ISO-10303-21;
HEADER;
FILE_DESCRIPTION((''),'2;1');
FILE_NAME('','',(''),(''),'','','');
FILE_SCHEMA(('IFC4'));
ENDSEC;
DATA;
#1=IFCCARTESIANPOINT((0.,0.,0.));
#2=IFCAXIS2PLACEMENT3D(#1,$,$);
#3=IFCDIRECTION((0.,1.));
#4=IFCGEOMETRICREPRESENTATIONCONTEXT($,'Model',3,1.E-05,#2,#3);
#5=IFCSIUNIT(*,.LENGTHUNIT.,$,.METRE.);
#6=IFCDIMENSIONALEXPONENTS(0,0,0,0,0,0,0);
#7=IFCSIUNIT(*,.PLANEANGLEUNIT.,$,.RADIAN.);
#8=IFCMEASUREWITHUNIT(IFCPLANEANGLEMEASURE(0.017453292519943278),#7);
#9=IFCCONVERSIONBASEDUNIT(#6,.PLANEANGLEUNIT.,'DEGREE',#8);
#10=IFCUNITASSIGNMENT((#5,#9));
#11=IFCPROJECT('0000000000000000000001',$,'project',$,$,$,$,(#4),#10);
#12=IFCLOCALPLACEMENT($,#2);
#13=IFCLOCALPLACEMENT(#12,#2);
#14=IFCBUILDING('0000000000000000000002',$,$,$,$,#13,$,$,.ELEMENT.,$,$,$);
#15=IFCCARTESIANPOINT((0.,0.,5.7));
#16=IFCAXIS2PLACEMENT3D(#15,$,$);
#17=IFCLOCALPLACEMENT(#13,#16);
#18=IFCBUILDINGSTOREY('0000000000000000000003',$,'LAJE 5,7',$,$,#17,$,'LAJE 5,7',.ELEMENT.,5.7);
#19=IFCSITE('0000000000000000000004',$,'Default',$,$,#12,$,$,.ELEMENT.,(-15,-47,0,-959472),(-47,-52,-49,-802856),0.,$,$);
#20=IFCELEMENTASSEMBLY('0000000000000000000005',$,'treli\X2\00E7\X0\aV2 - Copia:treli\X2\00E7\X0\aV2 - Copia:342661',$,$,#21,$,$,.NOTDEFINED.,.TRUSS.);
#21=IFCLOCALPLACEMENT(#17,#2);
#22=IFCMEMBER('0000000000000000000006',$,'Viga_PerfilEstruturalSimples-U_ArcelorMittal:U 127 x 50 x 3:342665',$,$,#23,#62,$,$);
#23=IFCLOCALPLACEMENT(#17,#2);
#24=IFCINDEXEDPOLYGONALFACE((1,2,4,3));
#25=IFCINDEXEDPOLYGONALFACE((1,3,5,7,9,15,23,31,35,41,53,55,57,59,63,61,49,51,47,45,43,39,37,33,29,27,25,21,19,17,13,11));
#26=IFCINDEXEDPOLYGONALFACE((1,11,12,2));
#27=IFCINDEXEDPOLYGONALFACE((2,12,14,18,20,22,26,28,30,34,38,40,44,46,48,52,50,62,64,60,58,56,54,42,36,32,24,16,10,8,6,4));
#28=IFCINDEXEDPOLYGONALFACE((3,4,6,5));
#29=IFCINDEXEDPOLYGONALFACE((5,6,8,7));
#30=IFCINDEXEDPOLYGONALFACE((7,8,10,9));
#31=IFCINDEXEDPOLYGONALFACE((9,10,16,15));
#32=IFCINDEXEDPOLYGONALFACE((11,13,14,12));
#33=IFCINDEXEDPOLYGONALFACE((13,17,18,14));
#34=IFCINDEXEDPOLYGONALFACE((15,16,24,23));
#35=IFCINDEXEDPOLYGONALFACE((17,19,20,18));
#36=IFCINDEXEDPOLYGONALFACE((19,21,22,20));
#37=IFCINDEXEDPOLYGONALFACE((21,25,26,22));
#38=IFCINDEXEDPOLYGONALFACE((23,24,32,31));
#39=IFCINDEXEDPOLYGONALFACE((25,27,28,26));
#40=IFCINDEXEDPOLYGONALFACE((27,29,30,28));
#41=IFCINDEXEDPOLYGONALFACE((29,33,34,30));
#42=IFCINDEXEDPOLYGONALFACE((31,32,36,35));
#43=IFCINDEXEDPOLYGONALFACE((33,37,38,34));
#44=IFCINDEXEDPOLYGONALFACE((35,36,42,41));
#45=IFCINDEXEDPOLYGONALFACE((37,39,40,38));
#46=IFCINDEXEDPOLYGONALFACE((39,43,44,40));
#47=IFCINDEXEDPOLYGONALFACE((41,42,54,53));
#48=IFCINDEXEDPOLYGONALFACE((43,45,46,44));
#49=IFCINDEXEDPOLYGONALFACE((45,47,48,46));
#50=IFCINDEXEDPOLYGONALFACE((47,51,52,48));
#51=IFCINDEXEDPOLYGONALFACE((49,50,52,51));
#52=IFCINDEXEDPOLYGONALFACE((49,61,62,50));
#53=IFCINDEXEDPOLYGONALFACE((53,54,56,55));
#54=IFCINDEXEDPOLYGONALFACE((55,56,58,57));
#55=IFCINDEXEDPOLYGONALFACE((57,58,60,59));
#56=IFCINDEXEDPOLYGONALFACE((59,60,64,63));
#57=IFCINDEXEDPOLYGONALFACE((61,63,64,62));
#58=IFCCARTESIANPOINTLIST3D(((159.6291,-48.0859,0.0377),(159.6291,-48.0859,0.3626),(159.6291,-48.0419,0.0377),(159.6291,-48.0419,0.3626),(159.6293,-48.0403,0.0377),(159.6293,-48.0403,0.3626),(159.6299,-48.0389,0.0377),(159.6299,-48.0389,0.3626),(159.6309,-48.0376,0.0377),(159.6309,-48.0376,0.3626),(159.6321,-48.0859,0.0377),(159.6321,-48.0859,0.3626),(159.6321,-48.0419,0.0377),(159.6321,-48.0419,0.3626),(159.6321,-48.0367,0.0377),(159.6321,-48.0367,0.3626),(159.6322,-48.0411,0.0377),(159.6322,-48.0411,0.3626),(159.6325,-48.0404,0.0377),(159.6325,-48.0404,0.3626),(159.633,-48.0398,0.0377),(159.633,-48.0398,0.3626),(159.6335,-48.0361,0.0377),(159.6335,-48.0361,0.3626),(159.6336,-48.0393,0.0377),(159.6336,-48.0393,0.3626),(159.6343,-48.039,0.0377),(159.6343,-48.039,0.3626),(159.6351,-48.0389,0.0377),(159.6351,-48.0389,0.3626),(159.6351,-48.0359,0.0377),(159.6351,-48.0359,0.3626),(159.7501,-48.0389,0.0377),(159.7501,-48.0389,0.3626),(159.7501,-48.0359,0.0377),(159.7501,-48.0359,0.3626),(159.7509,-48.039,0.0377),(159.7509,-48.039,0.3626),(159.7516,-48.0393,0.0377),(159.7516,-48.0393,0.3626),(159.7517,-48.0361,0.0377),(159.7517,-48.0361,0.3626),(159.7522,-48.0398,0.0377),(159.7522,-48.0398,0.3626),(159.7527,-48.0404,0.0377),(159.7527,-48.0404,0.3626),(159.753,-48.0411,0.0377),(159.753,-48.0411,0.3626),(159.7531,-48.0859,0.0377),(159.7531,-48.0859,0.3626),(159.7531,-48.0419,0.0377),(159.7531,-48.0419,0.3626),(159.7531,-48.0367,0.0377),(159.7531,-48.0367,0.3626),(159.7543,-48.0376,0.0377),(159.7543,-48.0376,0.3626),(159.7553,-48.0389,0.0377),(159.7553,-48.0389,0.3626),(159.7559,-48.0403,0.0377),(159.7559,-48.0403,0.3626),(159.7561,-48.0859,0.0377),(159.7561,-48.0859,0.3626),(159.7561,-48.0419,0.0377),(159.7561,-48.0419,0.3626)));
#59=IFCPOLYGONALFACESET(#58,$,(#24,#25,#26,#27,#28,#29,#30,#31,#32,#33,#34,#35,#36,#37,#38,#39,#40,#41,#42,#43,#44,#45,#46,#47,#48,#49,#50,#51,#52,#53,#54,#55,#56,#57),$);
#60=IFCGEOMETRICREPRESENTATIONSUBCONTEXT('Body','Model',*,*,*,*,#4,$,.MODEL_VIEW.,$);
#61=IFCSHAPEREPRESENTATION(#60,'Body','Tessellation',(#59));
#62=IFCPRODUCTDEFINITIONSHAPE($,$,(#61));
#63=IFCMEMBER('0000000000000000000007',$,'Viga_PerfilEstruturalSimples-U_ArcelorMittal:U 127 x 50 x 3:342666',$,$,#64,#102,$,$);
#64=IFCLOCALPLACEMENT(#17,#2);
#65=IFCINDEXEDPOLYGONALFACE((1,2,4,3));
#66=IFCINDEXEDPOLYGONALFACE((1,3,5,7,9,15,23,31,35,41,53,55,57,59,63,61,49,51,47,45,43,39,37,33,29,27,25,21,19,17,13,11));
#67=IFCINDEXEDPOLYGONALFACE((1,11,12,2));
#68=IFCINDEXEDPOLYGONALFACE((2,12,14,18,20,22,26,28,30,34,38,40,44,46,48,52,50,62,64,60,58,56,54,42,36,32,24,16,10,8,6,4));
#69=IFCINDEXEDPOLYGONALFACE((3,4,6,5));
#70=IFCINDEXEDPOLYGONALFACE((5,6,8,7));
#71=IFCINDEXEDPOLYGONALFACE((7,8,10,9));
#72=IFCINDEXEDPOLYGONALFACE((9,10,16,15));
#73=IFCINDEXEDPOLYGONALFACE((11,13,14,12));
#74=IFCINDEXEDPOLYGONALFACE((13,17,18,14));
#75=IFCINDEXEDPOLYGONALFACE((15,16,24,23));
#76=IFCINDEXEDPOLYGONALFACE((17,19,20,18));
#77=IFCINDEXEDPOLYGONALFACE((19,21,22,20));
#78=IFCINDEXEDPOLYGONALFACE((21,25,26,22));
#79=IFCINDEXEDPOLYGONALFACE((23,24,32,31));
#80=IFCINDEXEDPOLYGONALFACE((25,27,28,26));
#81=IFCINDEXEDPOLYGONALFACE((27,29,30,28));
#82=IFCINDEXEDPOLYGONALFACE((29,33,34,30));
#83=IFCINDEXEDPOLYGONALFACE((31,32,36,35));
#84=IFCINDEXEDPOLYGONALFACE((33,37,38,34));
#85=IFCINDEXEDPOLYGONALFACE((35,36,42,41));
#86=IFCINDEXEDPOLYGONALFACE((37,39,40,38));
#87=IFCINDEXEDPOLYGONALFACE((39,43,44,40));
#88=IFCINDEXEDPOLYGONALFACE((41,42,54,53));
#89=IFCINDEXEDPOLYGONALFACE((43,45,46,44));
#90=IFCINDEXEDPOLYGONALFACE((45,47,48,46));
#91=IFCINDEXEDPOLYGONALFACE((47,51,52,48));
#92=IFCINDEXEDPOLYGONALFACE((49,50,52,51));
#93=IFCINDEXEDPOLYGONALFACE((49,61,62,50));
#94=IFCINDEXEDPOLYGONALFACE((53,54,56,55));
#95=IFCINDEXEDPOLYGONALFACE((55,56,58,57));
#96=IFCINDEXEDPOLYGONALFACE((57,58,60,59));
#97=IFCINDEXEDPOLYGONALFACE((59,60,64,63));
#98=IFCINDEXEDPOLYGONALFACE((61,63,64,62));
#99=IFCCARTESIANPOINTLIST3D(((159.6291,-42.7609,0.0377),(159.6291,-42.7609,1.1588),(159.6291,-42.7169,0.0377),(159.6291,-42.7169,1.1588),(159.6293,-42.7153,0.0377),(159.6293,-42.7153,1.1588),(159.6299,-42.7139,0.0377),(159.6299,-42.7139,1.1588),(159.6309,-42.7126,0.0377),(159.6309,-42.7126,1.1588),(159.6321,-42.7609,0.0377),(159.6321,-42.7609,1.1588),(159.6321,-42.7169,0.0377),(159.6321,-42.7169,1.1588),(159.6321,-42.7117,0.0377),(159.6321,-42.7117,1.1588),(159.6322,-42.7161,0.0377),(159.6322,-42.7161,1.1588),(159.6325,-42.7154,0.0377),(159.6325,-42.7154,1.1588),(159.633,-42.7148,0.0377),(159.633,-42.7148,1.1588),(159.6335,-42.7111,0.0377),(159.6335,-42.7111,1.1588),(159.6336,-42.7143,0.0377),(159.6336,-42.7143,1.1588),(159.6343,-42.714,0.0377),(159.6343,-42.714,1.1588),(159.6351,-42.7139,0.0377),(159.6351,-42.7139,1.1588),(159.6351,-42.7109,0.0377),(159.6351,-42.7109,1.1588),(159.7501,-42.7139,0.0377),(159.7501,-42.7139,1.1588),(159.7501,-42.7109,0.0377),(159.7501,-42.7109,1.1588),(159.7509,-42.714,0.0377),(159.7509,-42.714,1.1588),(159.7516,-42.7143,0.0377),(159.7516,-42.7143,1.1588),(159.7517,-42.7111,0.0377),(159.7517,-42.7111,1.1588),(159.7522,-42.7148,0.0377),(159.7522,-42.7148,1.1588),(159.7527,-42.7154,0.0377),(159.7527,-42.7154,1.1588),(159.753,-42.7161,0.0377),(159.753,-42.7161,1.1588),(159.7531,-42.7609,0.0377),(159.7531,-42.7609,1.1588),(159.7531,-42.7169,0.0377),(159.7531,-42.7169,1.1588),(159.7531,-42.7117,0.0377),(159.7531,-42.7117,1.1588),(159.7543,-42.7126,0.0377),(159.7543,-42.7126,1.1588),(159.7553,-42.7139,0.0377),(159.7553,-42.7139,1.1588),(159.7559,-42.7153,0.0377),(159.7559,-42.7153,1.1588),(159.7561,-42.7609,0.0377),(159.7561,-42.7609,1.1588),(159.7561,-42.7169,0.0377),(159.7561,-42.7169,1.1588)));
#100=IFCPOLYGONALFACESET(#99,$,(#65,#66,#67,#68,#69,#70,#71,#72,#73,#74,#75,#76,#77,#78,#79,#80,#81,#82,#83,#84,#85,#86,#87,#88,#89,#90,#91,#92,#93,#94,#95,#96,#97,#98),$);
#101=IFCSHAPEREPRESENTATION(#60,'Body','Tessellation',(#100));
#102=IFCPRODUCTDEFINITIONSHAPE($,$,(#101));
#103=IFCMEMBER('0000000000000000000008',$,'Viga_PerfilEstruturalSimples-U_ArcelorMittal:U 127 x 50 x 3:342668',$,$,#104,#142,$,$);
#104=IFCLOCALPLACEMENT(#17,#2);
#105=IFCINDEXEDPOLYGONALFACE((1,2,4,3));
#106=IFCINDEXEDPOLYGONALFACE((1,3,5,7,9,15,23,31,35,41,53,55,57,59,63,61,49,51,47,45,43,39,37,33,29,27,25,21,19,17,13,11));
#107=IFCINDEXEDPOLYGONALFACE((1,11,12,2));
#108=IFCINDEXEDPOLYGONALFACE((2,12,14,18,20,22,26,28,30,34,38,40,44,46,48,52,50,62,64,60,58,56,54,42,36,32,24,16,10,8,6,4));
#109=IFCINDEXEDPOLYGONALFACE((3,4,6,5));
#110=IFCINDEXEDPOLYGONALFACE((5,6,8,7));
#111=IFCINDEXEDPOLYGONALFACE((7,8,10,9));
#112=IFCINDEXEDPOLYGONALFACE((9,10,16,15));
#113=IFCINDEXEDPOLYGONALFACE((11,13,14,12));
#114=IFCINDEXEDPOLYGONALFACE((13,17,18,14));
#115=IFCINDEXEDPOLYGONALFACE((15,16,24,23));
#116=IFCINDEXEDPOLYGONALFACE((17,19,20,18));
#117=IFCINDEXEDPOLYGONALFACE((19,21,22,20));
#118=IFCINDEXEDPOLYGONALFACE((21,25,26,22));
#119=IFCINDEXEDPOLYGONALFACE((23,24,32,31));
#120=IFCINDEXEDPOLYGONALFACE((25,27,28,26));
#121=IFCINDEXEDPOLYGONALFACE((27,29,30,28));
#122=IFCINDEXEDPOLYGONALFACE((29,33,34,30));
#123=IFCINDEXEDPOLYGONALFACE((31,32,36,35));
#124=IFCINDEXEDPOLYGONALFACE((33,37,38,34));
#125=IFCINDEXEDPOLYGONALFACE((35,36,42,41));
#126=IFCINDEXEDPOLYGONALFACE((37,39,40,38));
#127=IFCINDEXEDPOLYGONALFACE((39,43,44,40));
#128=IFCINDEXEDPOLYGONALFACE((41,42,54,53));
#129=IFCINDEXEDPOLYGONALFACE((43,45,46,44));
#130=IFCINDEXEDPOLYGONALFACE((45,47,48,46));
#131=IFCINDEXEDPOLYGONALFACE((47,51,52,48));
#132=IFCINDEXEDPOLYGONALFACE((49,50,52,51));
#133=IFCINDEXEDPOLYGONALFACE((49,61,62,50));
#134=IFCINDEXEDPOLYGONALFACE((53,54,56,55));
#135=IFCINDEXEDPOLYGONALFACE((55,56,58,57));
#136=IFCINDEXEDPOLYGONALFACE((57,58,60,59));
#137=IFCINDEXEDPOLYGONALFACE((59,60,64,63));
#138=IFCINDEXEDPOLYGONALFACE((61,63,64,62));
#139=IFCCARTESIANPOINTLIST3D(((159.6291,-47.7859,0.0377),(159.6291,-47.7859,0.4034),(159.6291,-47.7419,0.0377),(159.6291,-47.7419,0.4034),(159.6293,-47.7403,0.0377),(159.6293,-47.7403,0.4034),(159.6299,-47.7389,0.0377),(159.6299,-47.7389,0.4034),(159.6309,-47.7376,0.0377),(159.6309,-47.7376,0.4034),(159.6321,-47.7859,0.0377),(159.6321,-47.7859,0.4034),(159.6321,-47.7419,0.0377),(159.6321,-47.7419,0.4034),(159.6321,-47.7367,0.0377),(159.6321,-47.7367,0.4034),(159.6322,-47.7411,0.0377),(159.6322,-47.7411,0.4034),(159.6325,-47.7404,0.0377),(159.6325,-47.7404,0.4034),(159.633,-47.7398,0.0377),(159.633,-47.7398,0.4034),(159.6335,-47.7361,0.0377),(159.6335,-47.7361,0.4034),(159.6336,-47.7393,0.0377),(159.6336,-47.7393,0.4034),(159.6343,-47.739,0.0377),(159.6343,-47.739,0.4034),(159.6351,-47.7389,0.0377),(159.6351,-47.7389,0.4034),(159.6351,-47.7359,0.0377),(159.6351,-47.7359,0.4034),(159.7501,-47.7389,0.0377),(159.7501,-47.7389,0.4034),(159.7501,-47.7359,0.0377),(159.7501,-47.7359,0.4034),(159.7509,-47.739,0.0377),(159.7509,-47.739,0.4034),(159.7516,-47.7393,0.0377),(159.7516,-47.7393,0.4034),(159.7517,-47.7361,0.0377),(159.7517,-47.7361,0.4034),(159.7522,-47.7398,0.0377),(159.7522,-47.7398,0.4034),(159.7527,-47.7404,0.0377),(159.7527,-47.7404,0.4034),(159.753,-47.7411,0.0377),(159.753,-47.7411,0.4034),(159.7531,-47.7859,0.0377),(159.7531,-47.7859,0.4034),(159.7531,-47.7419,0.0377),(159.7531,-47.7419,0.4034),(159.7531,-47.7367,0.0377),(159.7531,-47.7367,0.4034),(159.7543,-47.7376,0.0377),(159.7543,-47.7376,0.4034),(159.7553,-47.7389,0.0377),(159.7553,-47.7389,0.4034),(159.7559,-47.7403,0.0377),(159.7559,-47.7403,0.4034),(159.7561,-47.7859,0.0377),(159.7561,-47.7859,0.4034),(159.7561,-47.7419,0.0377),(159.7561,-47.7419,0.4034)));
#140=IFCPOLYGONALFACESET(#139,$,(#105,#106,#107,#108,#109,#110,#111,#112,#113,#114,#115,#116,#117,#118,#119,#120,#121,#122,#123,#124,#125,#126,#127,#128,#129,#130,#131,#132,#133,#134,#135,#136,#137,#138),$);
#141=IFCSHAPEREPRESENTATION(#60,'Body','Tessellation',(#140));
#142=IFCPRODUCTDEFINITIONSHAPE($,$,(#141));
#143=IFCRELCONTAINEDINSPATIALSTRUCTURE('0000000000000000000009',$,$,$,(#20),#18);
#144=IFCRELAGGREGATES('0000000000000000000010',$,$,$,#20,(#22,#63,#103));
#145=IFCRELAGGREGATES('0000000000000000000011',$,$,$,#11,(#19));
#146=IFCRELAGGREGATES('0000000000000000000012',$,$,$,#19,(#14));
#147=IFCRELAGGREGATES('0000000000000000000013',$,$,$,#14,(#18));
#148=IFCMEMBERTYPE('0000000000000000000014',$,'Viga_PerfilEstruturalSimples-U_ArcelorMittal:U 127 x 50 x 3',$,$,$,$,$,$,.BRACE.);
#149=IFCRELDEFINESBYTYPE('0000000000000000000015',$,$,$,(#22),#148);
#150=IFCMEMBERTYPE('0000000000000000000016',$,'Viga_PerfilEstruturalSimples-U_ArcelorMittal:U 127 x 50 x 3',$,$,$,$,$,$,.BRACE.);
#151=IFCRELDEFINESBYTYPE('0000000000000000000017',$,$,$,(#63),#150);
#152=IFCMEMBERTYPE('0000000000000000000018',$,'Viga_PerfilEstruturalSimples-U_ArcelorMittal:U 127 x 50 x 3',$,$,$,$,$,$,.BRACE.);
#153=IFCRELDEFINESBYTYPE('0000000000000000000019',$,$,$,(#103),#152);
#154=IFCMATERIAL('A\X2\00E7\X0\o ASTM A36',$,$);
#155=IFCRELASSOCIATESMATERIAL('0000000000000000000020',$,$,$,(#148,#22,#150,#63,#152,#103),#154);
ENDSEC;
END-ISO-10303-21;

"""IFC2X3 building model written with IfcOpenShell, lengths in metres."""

from ifc_helpers import new_model, entity, si_unit, converted_unit, direction, frame, frame_2d, origin, place, context, subcontext, project, spatial, polyline, circle_curve, parameter, trimmed, segment, composite_curve, outline, extrude, source, transform, mapped, material, type_object, type_shapes, element, aggregate, save


model = new_model("IFC2X3")

# Units and contexts
model_context = context("Model", 3, precision=1e-05, world=origin(), true_north=direction((0.0, 1.0)))
body_context = subcontext(model_context, "Body", "Model", "MODEL_VIEW")
ifc_project = project(units=[si_unit("LENGTHUNIT", "METRE"), converted_unit("PLANEANGLEUNIT", "DEGREE", entity("IfcPlaneAngleMeasure", 0.017453292519943278), si_unit("PLANEANGLEUNIT", "RADIAN"), dimensions=[0, 0, 0, 0, 0, 0, 0])], contexts=[model_context])

# Site, building, storey
site_placement = place(None, origin())
site = spatial("IfcSite", under=ifc_project, at=site_placement, Name="Default", CompositionType="ELEMENT", RefLatitude=(-15, -47, 0, -959472), RefLongitude=(-47, -52, -49, -802856), RefElevation=0.0)
building_placement = place(site_placement, origin())
building = spatial("IfcBuilding", under=site, at=building_placement, CompositionType="ELEMENT")
storey_placement = place(building_placement, frame((0.0, 0.0, 5.7)))
storey = spatial("IfcBuildingStorey", under=building, at=storey_placement, Name="LAJE 5,7", LongName="LAJE 5,7", CompositionType="ELEMENT", Elevation=5.7)

# Element assembly, members
assembly_1_placement = place(storey_placement, origin())
assembly_1 = element("IfcElementAssembly", 1, at=assembly_1_placement, inside=storey, Name="treliçaV2 - Copia:treliçaV2 - Copia:342661", AssemblyPlace="NOTDEFINED", PredefinedType="TRUSS")
ifc_material = material(Name="Aço ASTM A36")
member_type_1 = type_object("IfcMemberType", Name="Viga_PerfilEstruturalSimples-U_ArcelorMittal:U 127 x 50 x 3", PredefinedType="BRACE", material=ifc_material)
shared_shape_1 = source(origin(), body_context, "Body", "SweptSolid", [
    extrude(outline(composite_curve([segment(polyline([(-0.0575, -0.0192), (0.0575, -0.0192)]), True, "CONTINUOUS"), segment(trimmed(circle_curve(frame_2d((0.0575, -0.0132), x_axis=(0.0, 1.0)), 0.006), [parameter(180.0)], [parameter(270.0)], True, "PARAMETER"), True, "CONTINUOUS"), segment(polyline([(0.0635, -0.0132), (0.0635, 0.0308)]), True, "CONTINUOUS"), segment(polyline([(0.0635, 0.0308), (0.0605, 0.0308)]), True, "CONTINUOUS"), segment(polyline([(0.0605, 0.0308), (0.0605, -0.0132)]), True, "CONTINUOUS"), segment(trimmed(circle_curve(frame_2d((0.0575, -0.0132), x_axis=(0.0, 1.0)), 0.003), [parameter(180.0)], [parameter(270.0)], True, "PARAMETER"), False, "CONTINUOUS"), segment(polyline([(0.0575, -0.0162), (-0.0575, -0.0162)]), True, "CONTINUOUS"), segment(trimmed(circle_curve(frame_2d((-0.0575, -0.0132), x_axis=(0.0, 1.0)), 0.003), [parameter(90.0)], [parameter(180.0)], True, "PARAMETER"), False, "CONTINUOUS"), segment(polyline([(-0.0605, -0.0132), (-0.0605, 0.0308)]), True, "CONTINUOUS"), segment(polyline([(-0.0605, 0.0308), (-0.0635, 0.0308)]), True, "CONTINUOUS"), segment(polyline([(-0.0635, 0.0308), (-0.0635, -0.0132)]), True, "CONTINUOUS"), segment(trimmed(circle_curve(frame_2d((-0.0575, -0.0132), x_axis=(0.0, 1.0)), 0.006), [parameter(90.0)], [parameter(180.0)], True, "PARAMETER"), True, "CONTINUOUS")], self_intersect=False)), frame((-0.1623, -0.0058, 0.0), z_axis=(1.0, 0.0, 0.0), x_axis=(0.0, 0.0, -1.0)), (0.0, 0.0, 1.0), 0.3249),
])
type_shapes(member_type_1, [shared_shape_1])
member_1_placement = place(assembly_1_placement, frame((159.6926, -48.0609, 0.2), z_axis=(1.0, 0.0, 0.0), x_axis=(0.0, 0.0, 1.0)))
member_1 = element("IfcMember", 2, at=member_1_placement, type_object=member_type_1, material=ifc_material, Name="Viga_PerfilEstruturalSimples-U_ArcelorMittal:U 127 x 50 x 3:342665", context=body_context, shape_type="MappedRepresentation", body=[
    mapped(shared_shape_1, transform((0.0, 0.0, 0.0), scale=1.0)),
])
member_type_2 = type_object("IfcMemberType", Name="Viga_PerfilEstruturalSimples-U_ArcelorMittal:U 127 x 50 x 3", PredefinedType="BRACE", material=ifc_material)
shared_shape_2 = source(origin(), body_context, "Body", "SweptSolid", [
    extrude(outline(composite_curve([segment(polyline([(-0.0575, -0.0192), (0.0575, -0.0192)]), True, "CONTINUOUS"), segment(trimmed(circle_curve(frame_2d((0.0575, -0.0132), x_axis=(0.0, 1.0)), 0.006), [parameter(180.0)], [parameter(270.0)], True, "PARAMETER"), True, "CONTINUOUS"), segment(polyline([(0.0635, -0.0132), (0.0635, 0.0308)]), True, "CONTINUOUS"), segment(polyline([(0.0635, 0.0308), (0.0605, 0.0308)]), True, "CONTINUOUS"), segment(polyline([(0.0605, 0.0308), (0.0605, -0.0132)]), True, "CONTINUOUS"), segment(trimmed(circle_curve(frame_2d((0.0575, -0.0132), x_axis=(0.0, 1.0)), 0.003), [parameter(180.0)], [parameter(270.0)], True, "PARAMETER"), False, "CONTINUOUS"), segment(polyline([(0.0575, -0.0162), (-0.0575, -0.0162)]), True, "CONTINUOUS"), segment(trimmed(circle_curve(frame_2d((-0.0575, -0.0132), x_axis=(0.0, 1.0)), 0.003), [parameter(90.0)], [parameter(180.0)], True, "PARAMETER"), False, "CONTINUOUS"), segment(polyline([(-0.0605, -0.0132), (-0.0605, 0.0308)]), True, "CONTINUOUS"), segment(polyline([(-0.0605, 0.0308), (-0.0635, 0.0308)]), True, "CONTINUOUS"), segment(polyline([(-0.0635, 0.0308), (-0.0635, -0.0132)]), True, "CONTINUOUS"), segment(trimmed(circle_curve(frame_2d((-0.0575, -0.0132), x_axis=(0.0, 1.0)), 0.006), [parameter(90.0)], [parameter(180.0)], True, "PARAMETER"), True, "CONTINUOUS")], self_intersect=False)), frame((-0.5626, -0.0058, 0.0), z_axis=(1.0, 0.0, 0.0), x_axis=(0.0, 0.0, -1.0)), (0.0, 0.0, 1.0), 1.1211),
])
type_shapes(member_type_2, [shared_shape_2])
member_2_placement = place(assembly_1_placement, frame((159.6926, -42.7359, 0.6003), z_axis=(1.0, 0.0, 0.0), x_axis=(0.0, 0.0, 1.0)))
member_2 = element("IfcMember", 3, at=member_2_placement, type_object=member_type_2, material=ifc_material, Name="Viga_PerfilEstruturalSimples-U_ArcelorMittal:U 127 x 50 x 3:342666", context=body_context, shape_type="MappedRepresentation", body=[
    mapped(shared_shape_2, transform((0.0, 0.0, 0.0), scale=1.0)),
])
member_type_3 = type_object("IfcMemberType", Name="Viga_PerfilEstruturalSimples-U_ArcelorMittal:U 127 x 50 x 3", PredefinedType="BRACE", material=ifc_material)
shared_shape_3 = source(origin(), body_context, "Body", "SweptSolid", [
    extrude(outline(composite_curve([segment(polyline([(-0.0575, -0.0192), (0.0575, -0.0192)]), True, "CONTINUOUS"), segment(trimmed(circle_curve(frame_2d((0.0575, -0.0132), x_axis=(0.0, 1.0)), 0.006), [parameter(180.0)], [parameter(270.0)], True, "PARAMETER"), True, "CONTINUOUS"), segment(polyline([(0.0635, -0.0132), (0.0635, 0.0308)]), True, "CONTINUOUS"), segment(polyline([(0.0635, 0.0308), (0.0605, 0.0308)]), True, "CONTINUOUS"), segment(polyline([(0.0605, 0.0308), (0.0605, -0.0132)]), True, "CONTINUOUS"), segment(trimmed(circle_curve(frame_2d((0.0575, -0.0132), x_axis=(0.0, 1.0)), 0.003), [parameter(180.0)], [parameter(270.0)], True, "PARAMETER"), False, "CONTINUOUS"), segment(polyline([(0.0575, -0.0162), (-0.0575, -0.0162)]), True, "CONTINUOUS"), segment(trimmed(circle_curve(frame_2d((-0.0575, -0.0132), x_axis=(0.0, 1.0)), 0.003), [parameter(90.0)], [parameter(180.0)], True, "PARAMETER"), False, "CONTINUOUS"), segment(polyline([(-0.0605, -0.0132), (-0.0605, 0.0308)]), True, "CONTINUOUS"), segment(polyline([(-0.0605, 0.0308), (-0.0635, 0.0308)]), True, "CONTINUOUS"), segment(polyline([(-0.0635, 0.0308), (-0.0635, -0.0132)]), True, "CONTINUOUS"), segment(trimmed(circle_curve(frame_2d((-0.0575, -0.0132), x_axis=(0.0, 1.0)), 0.006), [parameter(90.0)], [parameter(180.0)], True, "PARAMETER"), True, "CONTINUOUS")], self_intersect=False)), frame((-0.1849, -0.0058, 0.0), z_axis=(1.0, 0.0, 0.0), x_axis=(0.0, 0.0, -1.0)), (0.0, 0.0, 1.0), 0.3657),
])
type_shapes(member_type_3, [shared_shape_3])
member_3_placement = place(assembly_1_placement, frame((159.6926, -47.7609, 0.2226), z_axis=(1.0, 0.0, 0.0), x_axis=(0.0, 0.0, 1.0)))
member_3 = element("IfcMember", 4, at=member_3_placement, type_object=member_type_3, material=ifc_material, Name="Viga_PerfilEstruturalSimples-U_ArcelorMittal:U 127 x 50 x 3:342668", context=body_context, shape_type="MappedRepresentation", body=[
    mapped(shared_shape_3, transform((0.0, 0.0, 0.0), scale=1.0)),
])
aggregate(assembly_1, [member_1, member_2, member_3])

save(model, "model.ifc")
